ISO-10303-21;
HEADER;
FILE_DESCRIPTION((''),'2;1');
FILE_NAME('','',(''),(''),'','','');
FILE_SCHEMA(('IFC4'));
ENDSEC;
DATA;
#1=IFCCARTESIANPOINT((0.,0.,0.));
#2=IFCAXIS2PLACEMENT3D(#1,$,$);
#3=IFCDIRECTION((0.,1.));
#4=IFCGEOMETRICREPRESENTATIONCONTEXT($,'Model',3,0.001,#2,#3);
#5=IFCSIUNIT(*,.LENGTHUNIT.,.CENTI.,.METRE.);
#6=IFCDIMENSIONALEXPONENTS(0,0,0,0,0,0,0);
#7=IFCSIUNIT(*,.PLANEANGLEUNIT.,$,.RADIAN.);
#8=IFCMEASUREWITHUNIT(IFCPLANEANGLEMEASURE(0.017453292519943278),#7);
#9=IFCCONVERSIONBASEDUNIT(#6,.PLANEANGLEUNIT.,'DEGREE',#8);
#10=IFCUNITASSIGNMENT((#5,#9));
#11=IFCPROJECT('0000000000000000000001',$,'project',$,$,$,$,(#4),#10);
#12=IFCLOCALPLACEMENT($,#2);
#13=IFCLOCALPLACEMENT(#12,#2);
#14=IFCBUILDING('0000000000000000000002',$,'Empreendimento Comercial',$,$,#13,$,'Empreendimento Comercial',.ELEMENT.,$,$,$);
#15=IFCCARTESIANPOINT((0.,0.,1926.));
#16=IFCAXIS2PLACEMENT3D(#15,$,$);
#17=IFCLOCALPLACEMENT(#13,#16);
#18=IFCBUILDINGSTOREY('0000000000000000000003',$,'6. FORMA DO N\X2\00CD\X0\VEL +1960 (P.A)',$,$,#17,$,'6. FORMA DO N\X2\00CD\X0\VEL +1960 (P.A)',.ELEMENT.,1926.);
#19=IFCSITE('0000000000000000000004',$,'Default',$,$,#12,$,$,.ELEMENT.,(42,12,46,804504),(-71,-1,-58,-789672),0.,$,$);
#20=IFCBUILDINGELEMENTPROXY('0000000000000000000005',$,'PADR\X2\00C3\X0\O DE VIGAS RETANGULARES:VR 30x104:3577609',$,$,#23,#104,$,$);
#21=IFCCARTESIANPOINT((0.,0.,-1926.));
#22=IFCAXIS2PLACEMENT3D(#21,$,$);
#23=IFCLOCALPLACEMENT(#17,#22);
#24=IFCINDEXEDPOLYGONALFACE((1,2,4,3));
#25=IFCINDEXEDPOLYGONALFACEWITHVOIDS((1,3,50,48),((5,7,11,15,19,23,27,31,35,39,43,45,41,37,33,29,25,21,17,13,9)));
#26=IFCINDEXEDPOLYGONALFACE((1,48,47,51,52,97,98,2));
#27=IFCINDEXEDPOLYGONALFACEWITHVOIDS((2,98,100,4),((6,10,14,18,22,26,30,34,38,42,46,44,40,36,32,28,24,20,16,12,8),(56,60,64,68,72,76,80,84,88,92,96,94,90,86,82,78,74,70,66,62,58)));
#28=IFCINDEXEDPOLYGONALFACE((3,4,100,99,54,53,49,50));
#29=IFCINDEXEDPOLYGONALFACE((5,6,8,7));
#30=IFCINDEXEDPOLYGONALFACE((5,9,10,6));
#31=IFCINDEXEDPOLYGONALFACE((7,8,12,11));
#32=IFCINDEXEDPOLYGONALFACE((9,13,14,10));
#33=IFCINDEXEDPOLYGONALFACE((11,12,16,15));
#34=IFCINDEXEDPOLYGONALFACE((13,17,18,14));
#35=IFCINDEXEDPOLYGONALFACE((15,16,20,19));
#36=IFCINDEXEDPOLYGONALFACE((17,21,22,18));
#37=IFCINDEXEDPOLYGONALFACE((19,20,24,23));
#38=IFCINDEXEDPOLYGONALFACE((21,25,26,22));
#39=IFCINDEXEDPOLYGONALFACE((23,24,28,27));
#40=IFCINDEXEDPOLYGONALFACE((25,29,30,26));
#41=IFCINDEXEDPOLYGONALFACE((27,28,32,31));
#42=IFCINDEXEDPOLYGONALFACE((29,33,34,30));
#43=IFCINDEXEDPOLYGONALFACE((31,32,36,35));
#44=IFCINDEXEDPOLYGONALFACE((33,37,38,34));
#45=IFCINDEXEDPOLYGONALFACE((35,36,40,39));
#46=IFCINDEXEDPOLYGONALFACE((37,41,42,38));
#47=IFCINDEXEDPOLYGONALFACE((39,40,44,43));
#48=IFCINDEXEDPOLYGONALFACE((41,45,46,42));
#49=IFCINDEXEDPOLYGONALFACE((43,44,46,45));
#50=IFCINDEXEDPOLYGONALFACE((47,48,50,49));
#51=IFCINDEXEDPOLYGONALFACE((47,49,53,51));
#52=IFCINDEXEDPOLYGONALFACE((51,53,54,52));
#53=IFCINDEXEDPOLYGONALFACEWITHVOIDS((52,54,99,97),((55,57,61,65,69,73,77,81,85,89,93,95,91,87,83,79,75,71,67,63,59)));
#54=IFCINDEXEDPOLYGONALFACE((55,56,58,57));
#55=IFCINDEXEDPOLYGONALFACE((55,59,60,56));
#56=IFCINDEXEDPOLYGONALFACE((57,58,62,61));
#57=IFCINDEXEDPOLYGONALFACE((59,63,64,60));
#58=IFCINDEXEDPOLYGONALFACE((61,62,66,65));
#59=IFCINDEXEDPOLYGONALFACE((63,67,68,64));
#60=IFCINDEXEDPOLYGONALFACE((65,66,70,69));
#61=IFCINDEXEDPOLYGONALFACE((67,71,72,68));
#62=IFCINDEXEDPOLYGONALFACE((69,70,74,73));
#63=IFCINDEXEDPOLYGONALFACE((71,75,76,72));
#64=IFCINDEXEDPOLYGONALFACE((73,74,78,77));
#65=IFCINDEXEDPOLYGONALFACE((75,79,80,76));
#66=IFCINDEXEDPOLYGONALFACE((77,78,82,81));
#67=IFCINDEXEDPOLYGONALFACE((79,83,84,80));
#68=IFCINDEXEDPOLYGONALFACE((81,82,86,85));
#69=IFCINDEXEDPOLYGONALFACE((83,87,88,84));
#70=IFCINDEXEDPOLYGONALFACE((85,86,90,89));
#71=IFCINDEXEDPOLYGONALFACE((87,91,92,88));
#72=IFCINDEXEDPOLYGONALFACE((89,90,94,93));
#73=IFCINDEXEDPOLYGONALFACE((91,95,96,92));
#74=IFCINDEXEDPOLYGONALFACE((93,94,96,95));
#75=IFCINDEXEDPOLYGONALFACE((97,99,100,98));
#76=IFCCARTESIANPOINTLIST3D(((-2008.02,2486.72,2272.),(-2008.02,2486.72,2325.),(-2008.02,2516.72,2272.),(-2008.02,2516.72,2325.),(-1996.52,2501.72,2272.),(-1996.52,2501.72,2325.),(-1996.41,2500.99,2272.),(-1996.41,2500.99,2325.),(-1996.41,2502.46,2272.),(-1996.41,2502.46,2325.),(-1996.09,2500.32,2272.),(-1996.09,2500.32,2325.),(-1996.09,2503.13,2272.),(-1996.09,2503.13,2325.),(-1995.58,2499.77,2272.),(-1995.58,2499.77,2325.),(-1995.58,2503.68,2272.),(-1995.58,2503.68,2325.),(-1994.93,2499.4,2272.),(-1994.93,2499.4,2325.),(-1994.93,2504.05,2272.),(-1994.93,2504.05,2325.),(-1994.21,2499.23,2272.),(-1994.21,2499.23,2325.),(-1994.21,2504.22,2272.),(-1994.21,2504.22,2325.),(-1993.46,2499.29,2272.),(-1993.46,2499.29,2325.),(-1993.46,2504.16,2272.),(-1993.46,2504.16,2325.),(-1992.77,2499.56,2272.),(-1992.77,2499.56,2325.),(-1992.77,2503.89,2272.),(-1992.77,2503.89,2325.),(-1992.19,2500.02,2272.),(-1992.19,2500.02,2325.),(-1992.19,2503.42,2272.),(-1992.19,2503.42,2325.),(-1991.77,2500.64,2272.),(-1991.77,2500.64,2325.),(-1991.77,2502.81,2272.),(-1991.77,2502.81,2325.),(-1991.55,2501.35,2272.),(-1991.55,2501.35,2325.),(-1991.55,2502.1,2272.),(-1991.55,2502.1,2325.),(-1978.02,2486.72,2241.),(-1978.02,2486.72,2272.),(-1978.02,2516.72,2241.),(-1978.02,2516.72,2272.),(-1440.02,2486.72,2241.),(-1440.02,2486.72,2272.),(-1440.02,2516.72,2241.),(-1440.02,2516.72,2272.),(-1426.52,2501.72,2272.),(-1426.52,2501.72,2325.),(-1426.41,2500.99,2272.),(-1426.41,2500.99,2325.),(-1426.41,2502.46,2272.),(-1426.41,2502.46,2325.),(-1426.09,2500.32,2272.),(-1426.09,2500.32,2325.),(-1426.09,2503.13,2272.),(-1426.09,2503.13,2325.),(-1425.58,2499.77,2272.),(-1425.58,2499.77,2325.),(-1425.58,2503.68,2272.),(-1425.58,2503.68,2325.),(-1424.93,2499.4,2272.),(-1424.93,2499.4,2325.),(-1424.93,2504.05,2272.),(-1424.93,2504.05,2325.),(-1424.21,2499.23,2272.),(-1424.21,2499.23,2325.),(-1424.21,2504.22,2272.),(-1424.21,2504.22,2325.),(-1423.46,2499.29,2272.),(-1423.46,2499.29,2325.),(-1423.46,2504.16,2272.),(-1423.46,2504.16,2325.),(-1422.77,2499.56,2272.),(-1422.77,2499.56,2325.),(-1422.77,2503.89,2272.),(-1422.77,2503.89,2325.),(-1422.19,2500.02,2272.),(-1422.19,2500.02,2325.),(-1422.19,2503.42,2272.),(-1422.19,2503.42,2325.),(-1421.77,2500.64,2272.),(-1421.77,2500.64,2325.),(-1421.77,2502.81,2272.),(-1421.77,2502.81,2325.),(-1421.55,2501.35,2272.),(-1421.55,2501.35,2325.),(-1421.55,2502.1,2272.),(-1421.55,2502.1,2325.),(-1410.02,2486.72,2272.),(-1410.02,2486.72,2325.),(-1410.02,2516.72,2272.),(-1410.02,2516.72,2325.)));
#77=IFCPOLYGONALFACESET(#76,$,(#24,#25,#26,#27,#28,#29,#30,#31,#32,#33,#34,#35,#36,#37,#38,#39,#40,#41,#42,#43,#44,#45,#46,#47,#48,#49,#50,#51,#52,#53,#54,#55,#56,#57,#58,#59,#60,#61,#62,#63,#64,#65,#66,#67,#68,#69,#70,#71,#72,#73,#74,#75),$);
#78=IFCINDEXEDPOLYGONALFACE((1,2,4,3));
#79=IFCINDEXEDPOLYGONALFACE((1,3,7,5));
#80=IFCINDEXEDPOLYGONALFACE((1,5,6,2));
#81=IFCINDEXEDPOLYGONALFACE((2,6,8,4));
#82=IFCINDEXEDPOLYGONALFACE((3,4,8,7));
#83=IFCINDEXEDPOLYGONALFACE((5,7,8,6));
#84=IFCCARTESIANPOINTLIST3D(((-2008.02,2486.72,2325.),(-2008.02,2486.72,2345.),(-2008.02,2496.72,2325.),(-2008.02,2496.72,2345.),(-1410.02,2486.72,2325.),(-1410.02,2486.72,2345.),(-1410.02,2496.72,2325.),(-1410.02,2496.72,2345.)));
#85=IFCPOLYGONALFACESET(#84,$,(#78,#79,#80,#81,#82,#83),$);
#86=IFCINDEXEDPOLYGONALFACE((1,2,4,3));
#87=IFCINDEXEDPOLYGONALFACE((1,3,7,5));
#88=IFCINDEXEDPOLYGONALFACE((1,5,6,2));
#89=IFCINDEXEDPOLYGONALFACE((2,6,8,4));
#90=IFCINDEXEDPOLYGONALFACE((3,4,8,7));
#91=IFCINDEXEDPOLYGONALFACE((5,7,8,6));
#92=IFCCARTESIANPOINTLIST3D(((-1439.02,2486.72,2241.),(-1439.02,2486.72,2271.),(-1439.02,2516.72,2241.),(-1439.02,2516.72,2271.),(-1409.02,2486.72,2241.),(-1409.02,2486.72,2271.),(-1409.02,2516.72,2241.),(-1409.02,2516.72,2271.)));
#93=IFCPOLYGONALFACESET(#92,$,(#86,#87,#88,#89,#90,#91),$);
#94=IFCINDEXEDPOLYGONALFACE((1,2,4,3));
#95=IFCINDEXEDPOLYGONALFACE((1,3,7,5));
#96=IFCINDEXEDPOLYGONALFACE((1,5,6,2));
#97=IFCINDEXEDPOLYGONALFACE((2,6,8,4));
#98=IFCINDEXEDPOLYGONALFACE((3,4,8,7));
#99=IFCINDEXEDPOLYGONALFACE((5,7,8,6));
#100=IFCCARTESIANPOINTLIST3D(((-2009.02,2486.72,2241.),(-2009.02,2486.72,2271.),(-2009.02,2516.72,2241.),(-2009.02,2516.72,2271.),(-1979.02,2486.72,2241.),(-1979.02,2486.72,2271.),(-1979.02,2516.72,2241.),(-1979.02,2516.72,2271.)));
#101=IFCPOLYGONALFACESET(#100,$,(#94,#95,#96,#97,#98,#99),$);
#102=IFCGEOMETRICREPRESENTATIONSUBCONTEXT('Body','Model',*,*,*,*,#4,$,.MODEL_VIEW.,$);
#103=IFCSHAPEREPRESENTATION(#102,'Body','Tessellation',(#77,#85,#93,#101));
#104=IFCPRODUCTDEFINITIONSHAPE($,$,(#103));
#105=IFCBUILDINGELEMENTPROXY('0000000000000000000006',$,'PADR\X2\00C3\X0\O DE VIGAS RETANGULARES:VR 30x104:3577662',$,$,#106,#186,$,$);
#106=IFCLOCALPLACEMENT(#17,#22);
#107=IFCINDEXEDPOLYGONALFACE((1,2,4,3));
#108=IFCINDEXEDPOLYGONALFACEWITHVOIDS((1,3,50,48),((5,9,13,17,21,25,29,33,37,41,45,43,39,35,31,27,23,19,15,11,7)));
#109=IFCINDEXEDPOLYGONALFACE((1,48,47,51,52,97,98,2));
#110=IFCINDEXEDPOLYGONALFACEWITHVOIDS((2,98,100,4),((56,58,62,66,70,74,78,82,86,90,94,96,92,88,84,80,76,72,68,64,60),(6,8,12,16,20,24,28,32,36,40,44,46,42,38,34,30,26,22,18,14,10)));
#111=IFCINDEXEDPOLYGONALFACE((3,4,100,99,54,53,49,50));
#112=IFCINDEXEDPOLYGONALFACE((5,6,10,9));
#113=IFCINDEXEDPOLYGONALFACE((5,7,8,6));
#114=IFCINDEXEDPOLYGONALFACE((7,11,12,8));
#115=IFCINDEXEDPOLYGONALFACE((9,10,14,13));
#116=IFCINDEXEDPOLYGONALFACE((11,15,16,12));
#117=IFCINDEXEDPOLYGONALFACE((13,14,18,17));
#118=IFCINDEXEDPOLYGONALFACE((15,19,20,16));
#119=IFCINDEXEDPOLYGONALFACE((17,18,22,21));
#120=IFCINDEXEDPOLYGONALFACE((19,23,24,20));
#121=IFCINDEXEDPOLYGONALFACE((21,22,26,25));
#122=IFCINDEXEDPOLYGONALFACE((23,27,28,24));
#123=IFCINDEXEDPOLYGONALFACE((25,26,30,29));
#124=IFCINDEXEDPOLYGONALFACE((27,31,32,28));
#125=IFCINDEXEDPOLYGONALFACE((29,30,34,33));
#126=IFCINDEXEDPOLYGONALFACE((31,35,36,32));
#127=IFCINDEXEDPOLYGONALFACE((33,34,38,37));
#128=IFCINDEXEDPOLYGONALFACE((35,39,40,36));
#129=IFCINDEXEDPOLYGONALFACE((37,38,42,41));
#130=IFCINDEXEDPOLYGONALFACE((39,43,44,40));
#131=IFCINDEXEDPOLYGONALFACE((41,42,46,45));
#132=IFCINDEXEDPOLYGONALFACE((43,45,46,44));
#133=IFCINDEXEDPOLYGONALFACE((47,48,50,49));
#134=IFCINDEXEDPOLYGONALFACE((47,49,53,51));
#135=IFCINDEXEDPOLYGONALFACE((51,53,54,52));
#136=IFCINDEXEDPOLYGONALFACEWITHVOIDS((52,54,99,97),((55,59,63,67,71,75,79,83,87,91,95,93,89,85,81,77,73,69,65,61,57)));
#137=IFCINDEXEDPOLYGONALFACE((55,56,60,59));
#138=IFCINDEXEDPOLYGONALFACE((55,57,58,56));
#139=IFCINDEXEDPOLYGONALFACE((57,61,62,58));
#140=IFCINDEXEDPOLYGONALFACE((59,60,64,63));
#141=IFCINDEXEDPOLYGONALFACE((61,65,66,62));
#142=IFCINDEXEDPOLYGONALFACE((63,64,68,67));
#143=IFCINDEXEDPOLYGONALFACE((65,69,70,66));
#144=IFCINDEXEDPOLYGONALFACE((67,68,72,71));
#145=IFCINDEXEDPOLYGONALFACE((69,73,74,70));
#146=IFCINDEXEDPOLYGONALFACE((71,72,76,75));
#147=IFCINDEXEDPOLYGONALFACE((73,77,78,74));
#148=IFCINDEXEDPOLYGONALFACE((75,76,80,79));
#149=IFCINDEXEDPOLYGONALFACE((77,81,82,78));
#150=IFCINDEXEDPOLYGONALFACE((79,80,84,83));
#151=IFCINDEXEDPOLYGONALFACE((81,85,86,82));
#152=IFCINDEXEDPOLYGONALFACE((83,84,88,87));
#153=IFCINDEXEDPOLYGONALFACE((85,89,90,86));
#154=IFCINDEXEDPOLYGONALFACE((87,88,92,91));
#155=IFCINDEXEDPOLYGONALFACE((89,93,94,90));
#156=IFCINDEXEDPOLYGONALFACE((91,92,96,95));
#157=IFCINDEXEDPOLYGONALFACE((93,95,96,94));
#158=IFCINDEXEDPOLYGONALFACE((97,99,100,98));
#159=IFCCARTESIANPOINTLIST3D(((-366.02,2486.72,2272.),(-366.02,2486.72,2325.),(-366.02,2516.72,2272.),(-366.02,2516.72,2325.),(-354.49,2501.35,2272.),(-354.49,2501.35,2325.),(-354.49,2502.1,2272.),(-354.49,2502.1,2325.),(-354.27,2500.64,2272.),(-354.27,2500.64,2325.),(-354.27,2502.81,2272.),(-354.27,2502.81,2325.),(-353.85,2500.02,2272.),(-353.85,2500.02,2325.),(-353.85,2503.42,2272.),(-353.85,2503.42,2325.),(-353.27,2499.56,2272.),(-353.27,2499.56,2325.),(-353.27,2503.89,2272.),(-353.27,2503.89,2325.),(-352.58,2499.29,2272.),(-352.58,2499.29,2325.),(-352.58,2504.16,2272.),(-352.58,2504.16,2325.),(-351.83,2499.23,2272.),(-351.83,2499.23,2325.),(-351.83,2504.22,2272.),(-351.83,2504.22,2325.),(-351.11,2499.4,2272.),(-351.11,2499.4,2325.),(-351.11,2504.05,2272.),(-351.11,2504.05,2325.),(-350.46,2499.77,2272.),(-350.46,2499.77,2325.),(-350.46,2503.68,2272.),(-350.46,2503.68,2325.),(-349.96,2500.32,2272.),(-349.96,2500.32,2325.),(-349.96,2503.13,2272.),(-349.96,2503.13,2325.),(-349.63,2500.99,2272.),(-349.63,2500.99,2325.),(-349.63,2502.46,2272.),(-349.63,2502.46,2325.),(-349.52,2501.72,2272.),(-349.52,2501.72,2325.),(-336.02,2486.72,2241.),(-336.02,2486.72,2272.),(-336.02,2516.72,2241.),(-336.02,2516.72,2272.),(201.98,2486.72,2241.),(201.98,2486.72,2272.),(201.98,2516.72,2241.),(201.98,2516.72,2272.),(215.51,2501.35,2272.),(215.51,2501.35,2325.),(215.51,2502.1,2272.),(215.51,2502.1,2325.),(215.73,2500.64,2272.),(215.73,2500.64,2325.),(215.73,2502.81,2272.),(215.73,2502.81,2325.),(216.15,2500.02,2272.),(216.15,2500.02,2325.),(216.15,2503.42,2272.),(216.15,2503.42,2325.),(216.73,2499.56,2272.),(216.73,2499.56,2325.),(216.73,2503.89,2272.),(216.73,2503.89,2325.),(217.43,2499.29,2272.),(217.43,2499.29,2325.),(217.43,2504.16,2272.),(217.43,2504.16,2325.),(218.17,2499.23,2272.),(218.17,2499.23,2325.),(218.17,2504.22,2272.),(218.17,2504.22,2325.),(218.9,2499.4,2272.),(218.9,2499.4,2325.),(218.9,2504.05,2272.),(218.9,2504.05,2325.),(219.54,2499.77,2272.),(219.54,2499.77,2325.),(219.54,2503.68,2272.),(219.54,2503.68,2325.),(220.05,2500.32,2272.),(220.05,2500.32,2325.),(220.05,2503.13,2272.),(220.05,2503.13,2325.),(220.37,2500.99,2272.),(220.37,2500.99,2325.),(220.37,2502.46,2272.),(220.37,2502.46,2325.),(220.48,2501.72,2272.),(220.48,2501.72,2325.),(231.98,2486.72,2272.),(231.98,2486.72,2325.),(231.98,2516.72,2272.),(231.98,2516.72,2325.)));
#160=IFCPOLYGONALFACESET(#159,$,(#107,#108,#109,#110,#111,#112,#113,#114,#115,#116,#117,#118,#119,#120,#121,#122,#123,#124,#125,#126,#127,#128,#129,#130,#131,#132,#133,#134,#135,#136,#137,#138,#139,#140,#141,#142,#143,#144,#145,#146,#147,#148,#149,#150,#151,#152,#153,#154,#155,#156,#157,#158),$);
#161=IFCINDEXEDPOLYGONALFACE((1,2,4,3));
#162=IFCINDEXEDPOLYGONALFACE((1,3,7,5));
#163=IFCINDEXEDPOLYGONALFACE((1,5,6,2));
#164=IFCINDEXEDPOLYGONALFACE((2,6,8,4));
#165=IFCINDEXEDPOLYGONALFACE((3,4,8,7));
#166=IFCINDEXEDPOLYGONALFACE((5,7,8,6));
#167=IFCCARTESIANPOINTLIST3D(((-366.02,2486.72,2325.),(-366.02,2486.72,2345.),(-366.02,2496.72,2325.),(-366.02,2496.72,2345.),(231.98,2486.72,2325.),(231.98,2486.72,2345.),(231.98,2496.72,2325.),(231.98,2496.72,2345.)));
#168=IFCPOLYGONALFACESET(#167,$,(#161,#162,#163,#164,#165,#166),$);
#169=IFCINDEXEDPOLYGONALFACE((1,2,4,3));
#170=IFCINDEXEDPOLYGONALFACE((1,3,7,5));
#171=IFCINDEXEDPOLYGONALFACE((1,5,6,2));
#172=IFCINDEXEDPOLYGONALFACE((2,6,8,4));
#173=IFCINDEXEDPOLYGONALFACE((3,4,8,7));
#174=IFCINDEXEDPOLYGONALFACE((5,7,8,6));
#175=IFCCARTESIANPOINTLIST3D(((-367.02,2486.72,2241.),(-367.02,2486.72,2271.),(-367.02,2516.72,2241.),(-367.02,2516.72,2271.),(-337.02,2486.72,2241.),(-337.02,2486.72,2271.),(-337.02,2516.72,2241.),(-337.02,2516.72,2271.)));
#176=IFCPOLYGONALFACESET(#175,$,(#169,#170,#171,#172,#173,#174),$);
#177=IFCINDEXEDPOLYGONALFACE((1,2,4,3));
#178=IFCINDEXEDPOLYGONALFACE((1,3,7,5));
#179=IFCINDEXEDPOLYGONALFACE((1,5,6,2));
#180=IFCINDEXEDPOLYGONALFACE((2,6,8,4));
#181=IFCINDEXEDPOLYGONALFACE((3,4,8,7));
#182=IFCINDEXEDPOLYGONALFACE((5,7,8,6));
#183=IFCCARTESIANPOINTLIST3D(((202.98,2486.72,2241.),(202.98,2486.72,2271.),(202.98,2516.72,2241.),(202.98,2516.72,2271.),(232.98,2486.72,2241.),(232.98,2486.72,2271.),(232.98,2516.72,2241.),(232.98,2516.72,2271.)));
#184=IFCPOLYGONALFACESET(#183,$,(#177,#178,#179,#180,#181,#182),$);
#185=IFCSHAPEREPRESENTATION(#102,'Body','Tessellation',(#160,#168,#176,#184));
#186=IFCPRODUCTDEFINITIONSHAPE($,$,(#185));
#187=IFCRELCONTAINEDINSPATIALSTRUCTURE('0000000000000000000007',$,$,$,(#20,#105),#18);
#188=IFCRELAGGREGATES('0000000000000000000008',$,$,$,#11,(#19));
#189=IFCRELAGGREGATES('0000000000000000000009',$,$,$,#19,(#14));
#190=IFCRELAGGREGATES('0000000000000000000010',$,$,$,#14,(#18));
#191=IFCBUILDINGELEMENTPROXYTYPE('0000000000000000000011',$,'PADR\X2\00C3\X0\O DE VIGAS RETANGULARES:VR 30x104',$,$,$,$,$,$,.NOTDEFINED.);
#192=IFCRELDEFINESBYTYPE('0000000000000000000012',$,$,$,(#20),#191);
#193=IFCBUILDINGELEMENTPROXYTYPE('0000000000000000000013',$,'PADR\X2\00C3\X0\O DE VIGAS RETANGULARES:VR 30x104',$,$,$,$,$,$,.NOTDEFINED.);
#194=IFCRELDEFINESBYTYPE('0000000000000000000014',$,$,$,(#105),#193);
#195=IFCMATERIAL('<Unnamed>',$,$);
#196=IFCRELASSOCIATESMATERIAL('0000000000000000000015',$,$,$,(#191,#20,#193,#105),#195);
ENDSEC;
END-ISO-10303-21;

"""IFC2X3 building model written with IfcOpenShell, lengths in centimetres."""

from ifc_helpers import new_model, entity, si_unit, converted_unit, direction, frame, frame_2d, origin, origin_2d_with_axis, place, context, subcontext, project, spatial, polyline, rectangle, circle, outline, extrude, source, transform, mapped, material, type_object, type_shapes, element, save


model = new_model("IFC2X3")

# Units and contexts
model_context = context("Model", 3, precision=0.001, world=origin(), true_north=direction((0.0, 1.0)))
body_context = subcontext(model_context, "Body", "Model", "MODEL_VIEW")
ifc_project = project(units=[si_unit("LENGTHUNIT", "METRE", prefix="CENTI"), converted_unit("PLANEANGLEUNIT", "DEGREE", entity("IfcPlaneAngleMeasure", 0.017453292519943278), si_unit("PLANEANGLEUNIT", "RADIAN"), dimensions=[0, 0, 0, 0, 0, 0, 0])], contexts=[model_context])

# Site, building, storey
site_placement = place(None, origin())
site = spatial("IfcSite", under=ifc_project, at=site_placement, Name="Default", CompositionType="ELEMENT", RefLatitude=(42, 12, 46, 804504), RefLongitude=(-71, -1, -58, -789672), RefElevation=0.0)
building_placement = place(site_placement, origin())
building = spatial("IfcBuilding", under=site, at=building_placement, Name="Empreendimento Comercial", LongName="Empreendimento Comercial", CompositionType="ELEMENT")
storey_placement = place(building_placement, frame((0.0, 0.0, 1926.0)))
storey = spatial("IfcBuildingStorey", under=building, at=storey_placement, Name="6. FORMA DO NÍVEL +1960 (P.A)", LongName="6. FORMA DO NÍVEL +1960 (P.A)", CompositionType="ELEMENT", Elevation=1926.0)

# Building element proxies, openings
ifc_material_1 = material(Name="<Unnamed>")
building_element_proxy_type_1 = type_object("IfcBuildingElementProxyType", Name="PADRÃO DE VIGAS RETANGULARES:VR 30x104", PredefinedType="NOTDEFINED", material=ifc_material_1)
shared_shape_1 = source(origin(), body_context, "Body", "SweptSolid", [
    extrude(outline(polyline([(-47.5, -299.0), (5.5, -299.0), (5.5, -269.0), (36.5, -269.0), (36.5, 269.0), (5.5, 269.0), (5.5, 299.0), (-47.5, 299.0), (-47.5, -299.0)])), frame((-1709.02, 2486.72, 2277.5), z_axis=(0.0, 1.0, 0.0), x_axis=(0.0, 0.0, -1.0)), (0.0, 0.0, 1.0), 30.0),
    extrude(rectangle(XDim=598.0, YDim=10.0, at=origin_2d_with_axis()), frame((-1709.02, 2491.72, 2325.0)), (0.0, 0.0, 1.0), 20.0),
    extrude(rectangle(XDim=30.0, YDim=30.0, at=frame_2d((0.0, 0.0), x_axis=(1.0, 0.0))), frame((-1424.02, 2501.72, 2241.0), z_axis=(0.0, 0.0, 1.0), x_axis=(0.0, -1.0, 0.0)), (0.0, 0.0, 1.0), 30.0),
    extrude(rectangle(XDim=30.0, YDim=30.0, at=frame_2d((0.0, 0.0), x_axis=(1.0, 0.0))), frame((-1994.02, 2501.72, 2241.0), z_axis=(0.0, 0.0, 1.0), x_axis=(0.0, -1.0, 0.0)), (0.0, 0.0, 1.0), 30.0),
])
type_shapes(building_element_proxy_type_1, [shared_shape_1])
proxy_1_placement = place(storey_placement, frame((0.0, 0.0, -1926.0)))
proxy_1 = element("IfcBuildingElementProxy", 1, at=proxy_1_placement, inside=storey, type_object=building_element_proxy_type_1, material=ifc_material_1, Name="PADRÃO DE VIGAS RETANGULARES:VR 30x104:3577609", context=body_context, shape_type="MappedRepresentation", body=[
    mapped(shared_shape_1, transform((0.0, 0.0, 0.0), scale=1.0)),
])
opening_1_placement = place(storey_placement, frame((0.0, 0.0, -1926.0)))
element("IfcOpeningElement", 2, at=opening_1_placement, cuts=proxy_1, ObjectType="Opening", context=body_context, shape_type="SweptSolid", body=[
    extrude(circle(Radius=2.5, at=origin_2d_with_axis()), frame((-1994.02, 2501.72, 2272.0), z_axis=(0.0, 0.0, 1.0), x_axis=(-1.0, 0.0, 0.0)), (0.0, 0.0, 1.0), 53.0),
])
opening_2_placement = place(storey_placement, frame((0.0, 0.0, -1926.0)))
element("IfcOpeningElement", 3, at=opening_2_placement, cuts=proxy_1, ObjectType="Opening", context=body_context, shape_type="SweptSolid", body=[
    extrude(circle(Radius=2.5, at=origin_2d_with_axis()), frame((-1424.02, 2501.72, 2272.0), z_axis=(0.0, 0.0, 1.0), x_axis=(-1.0, 0.0, 0.0)), (0.0, 0.0, 1.0), 53.0),
])
building_element_proxy_type_2 = type_object("IfcBuildingElementProxyType", Name="PADRÃO DE VIGAS RETANGULARES:VR 30x104", PredefinedType="NOTDEFINED", material=ifc_material_1)
shared_shape_2 = source(origin(), body_context, "Body", "SweptSolid", [
    extrude(outline(polyline([(-299.0, -47.5), (299.0, -47.5), (299.0, 5.5), (269.0, 5.5), (269.0, 36.5), (-269.0, 36.5), (-269.0, 5.5), (-299.0, 5.5), (-299.0, -47.5)])), frame((-67.02, 2486.72, 2277.5), z_axis=(0.0, 1.0, 0.0), x_axis=(1.0, 0.0, 0.0)), (0.0, 0.0, 1.0), 30.0),
    extrude(rectangle(XDim=10.0, YDim=598.0, at=frame_2d((0.0, 0.0), x_axis=(1.0, 0.0))), frame((-67.02, 2491.72, 2325.0), z_axis=(0.0, 0.0, 1.0), x_axis=(0.0, 1.0, 0.0)), (0.0, 0.0, 1.0), 20.0),
    extrude(rectangle(XDim=30.0, YDim=30.0, at=frame_2d((0.0, 0.0), x_axis=(1.0, 0.0))), frame((-352.02, 2501.72, 2241.0), z_axis=(0.0, 0.0, 1.0), x_axis=(-1.0, 0.0, 0.0)), (0.0, 0.0, 1.0), 30.0),
    extrude(rectangle(XDim=30.0, YDim=30.0, at=frame_2d((0.0, 0.0), x_axis=(1.0, 0.0))), frame((217.98, 2501.72, 2241.0), z_axis=(0.0, 0.0, 1.0), x_axis=(-1.0, 0.0, 0.0)), (0.0, 0.0, 1.0), 30.0),
])
type_shapes(building_element_proxy_type_2, [shared_shape_2])
proxy_2_placement = place(storey_placement, frame((0.0, 0.0, -1926.0)))
proxy_2 = element("IfcBuildingElementProxy", 4, at=proxy_2_placement, inside=storey, type_object=building_element_proxy_type_2, material=ifc_material_1, Name="PADRÃO DE VIGAS RETANGULARES:VR 30x104:3577662", context=body_context, shape_type="MappedRepresentation", body=[
    mapped(shared_shape_2, transform((0.0, 0.0, 0.0), scale=1.0)),
])
opening_3_placement = place(storey_placement, frame((0.0, 0.0, -1926.0)))
element("IfcOpeningElement", 5, at=opening_3_placement, cuts=proxy_2, ObjectType="Opening", context=body_context, shape_type="SweptSolid", body=[
    extrude(circle(Radius=2.5, at=origin_2d_with_axis()), frame((217.98, 2501.72, 2272.0)), (0.0, 0.0, 1.0), 53.0),
])
opening_4_placement = place(storey_placement, frame((0.0, 0.0, -1926.0)))
element("IfcOpeningElement", 6, at=opening_4_placement, cuts=proxy_2, ObjectType="Opening", context=body_context, shape_type="SweptSolid", body=[
    extrude(circle(Radius=2.5, at=origin_2d_with_axis()), frame((-352.02, 2501.72, 2272.0)), (0.0, 0.0, 1.0), 53.0),
])

save(model, "model.ifc")
